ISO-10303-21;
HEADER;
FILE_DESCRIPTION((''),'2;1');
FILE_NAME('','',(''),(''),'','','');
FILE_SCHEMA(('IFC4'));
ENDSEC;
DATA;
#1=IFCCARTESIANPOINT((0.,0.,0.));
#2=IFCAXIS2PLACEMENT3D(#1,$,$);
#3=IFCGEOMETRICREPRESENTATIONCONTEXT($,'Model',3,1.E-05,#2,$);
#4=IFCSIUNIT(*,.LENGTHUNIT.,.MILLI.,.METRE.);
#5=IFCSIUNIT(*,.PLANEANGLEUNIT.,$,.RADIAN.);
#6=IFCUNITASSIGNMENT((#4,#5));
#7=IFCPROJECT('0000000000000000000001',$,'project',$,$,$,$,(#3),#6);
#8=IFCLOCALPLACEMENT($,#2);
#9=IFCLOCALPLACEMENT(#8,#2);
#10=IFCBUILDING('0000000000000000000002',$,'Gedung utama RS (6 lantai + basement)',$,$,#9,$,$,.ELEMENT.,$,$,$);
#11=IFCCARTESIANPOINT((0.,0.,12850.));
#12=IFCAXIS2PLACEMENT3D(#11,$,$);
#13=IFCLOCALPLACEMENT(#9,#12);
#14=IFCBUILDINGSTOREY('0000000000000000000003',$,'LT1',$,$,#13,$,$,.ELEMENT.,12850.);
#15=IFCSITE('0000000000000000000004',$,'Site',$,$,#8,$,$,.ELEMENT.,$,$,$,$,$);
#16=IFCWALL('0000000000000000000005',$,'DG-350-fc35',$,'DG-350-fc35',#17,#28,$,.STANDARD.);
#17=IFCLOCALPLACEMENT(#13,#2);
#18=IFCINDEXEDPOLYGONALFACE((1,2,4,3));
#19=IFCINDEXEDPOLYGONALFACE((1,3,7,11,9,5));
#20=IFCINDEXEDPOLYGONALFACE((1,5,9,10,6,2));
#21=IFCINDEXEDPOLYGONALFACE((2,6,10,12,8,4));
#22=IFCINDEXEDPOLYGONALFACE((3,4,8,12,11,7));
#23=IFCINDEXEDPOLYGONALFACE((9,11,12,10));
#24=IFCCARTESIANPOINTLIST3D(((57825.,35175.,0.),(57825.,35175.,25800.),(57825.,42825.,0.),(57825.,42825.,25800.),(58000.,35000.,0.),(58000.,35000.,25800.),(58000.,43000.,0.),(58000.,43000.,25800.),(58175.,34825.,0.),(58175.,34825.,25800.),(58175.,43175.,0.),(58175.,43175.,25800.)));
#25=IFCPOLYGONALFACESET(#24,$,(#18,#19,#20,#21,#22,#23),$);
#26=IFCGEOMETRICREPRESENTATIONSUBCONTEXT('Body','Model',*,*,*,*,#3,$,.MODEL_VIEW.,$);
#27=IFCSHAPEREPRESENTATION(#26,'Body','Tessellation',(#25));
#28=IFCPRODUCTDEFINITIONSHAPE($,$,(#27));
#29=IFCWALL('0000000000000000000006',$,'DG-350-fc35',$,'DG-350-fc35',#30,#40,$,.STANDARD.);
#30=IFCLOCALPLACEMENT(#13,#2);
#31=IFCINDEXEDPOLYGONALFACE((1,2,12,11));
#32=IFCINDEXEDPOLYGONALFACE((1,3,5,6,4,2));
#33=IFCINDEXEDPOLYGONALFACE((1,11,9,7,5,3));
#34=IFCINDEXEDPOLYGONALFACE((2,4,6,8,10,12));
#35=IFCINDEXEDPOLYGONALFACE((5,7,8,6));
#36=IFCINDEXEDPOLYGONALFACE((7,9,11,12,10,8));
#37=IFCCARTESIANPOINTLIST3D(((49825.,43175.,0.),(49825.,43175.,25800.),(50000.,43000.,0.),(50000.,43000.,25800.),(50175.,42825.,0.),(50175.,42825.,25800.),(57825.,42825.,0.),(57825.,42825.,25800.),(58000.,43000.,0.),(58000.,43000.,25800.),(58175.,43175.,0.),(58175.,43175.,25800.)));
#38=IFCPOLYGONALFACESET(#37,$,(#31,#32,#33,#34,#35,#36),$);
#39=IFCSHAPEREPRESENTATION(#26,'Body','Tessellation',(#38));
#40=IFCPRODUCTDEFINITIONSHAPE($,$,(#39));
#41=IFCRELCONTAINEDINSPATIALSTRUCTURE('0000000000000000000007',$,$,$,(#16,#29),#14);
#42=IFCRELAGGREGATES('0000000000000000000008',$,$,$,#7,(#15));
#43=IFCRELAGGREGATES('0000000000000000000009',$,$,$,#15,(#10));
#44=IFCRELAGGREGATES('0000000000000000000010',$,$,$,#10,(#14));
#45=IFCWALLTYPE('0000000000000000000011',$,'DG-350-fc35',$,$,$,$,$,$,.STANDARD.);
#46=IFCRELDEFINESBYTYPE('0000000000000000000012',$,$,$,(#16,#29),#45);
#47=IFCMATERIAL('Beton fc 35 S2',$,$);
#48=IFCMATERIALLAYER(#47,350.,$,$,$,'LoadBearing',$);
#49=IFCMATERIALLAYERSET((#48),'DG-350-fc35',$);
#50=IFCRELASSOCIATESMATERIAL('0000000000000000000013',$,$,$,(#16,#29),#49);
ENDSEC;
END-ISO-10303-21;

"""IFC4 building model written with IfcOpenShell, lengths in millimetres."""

from ifc_helpers import new_model, si_unit, frame, origin, place, context, subcontext, project, spatial, polyline, outline, extrude, material, layer, layer_set, layer_usage, type_object, element, save


model = new_model("IFC4")

# Units and contexts
model_context = context("Model", 3, precision=1e-05, world=origin())
body_context = subcontext(model_context, "Body", "Model", "MODEL_VIEW")
ifc_project = project(units=[si_unit("LENGTHUNIT", "METRE", prefix="MILLI"), si_unit("PLANEANGLEUNIT", "RADIAN")], contexts=[model_context])

# Site, building, storey
site_placement = place(None, origin())
site = spatial("IfcSite", under=ifc_project, at=site_placement, Name="Site", CompositionType="ELEMENT")
building_placement = place(site_placement, origin())
building = spatial("IfcBuilding", under=site, at=building_placement, Name="Gedung utama RS (6 lantai + basement)", CompositionType="ELEMENT")
storey_placement = place(building_placement, frame((0.0, 0.0, 12850.0)))
storey = spatial("IfcBuildingStorey", under=building, at=storey_placement, Name="LT1", CompositionType="ELEMENT", Elevation=12850.0)

# Walls
ifc_material_1 = material(Name="Beton fc 35 S2")
ifc_layer = layer(ifc_material_1, 350.0, Category="LoadBearing")
ifc_layer_set = layer_set([ifc_layer], Name="DG-350-fc35")
ifc_layer_usage = layer_usage(ifc_layer_set, "AXIS2", "NEGATIVE", 175.0)
wall_type = type_object("IfcWallType", Name="DG-350-fc35", PredefinedType="STANDARD")
for number, where, z_axis, x_axis, name in (
    (1, (58000.0, 35000.0, 0.0), (0.0, 0.0, 1.0), (0.0, 1.0, 0.0), "DG-350-fc35"),
    (2, (58000.0, 43000.0, 0.0), (0.0, 0.0, 1.0), (-1.0, 0.0, 0.0), "DG-350-fc35"),
):
    element("IfcWall", number, at=place(storey_placement, frame(where, z_axis=z_axis, x_axis=x_axis)), inside=storey, type_object=wall_type, material=ifc_layer_usage, Name=name, ObjectType="DG-350-fc35", PredefinedType="STANDARD", context=body_context, shape_type="SweptSolid", body=[
        extrude(outline(polyline([(-175.0, -175.0), (0.0, 0.0), (175.0, 175.0), (7825.0, 175.0), (8000.0, 0.0), (8175.0, -175.0), (-175.0, -175.0)])), origin(), (0.0, 0.0, 1.0), 25800.0),
    ])

save(model, "model.ifc")
